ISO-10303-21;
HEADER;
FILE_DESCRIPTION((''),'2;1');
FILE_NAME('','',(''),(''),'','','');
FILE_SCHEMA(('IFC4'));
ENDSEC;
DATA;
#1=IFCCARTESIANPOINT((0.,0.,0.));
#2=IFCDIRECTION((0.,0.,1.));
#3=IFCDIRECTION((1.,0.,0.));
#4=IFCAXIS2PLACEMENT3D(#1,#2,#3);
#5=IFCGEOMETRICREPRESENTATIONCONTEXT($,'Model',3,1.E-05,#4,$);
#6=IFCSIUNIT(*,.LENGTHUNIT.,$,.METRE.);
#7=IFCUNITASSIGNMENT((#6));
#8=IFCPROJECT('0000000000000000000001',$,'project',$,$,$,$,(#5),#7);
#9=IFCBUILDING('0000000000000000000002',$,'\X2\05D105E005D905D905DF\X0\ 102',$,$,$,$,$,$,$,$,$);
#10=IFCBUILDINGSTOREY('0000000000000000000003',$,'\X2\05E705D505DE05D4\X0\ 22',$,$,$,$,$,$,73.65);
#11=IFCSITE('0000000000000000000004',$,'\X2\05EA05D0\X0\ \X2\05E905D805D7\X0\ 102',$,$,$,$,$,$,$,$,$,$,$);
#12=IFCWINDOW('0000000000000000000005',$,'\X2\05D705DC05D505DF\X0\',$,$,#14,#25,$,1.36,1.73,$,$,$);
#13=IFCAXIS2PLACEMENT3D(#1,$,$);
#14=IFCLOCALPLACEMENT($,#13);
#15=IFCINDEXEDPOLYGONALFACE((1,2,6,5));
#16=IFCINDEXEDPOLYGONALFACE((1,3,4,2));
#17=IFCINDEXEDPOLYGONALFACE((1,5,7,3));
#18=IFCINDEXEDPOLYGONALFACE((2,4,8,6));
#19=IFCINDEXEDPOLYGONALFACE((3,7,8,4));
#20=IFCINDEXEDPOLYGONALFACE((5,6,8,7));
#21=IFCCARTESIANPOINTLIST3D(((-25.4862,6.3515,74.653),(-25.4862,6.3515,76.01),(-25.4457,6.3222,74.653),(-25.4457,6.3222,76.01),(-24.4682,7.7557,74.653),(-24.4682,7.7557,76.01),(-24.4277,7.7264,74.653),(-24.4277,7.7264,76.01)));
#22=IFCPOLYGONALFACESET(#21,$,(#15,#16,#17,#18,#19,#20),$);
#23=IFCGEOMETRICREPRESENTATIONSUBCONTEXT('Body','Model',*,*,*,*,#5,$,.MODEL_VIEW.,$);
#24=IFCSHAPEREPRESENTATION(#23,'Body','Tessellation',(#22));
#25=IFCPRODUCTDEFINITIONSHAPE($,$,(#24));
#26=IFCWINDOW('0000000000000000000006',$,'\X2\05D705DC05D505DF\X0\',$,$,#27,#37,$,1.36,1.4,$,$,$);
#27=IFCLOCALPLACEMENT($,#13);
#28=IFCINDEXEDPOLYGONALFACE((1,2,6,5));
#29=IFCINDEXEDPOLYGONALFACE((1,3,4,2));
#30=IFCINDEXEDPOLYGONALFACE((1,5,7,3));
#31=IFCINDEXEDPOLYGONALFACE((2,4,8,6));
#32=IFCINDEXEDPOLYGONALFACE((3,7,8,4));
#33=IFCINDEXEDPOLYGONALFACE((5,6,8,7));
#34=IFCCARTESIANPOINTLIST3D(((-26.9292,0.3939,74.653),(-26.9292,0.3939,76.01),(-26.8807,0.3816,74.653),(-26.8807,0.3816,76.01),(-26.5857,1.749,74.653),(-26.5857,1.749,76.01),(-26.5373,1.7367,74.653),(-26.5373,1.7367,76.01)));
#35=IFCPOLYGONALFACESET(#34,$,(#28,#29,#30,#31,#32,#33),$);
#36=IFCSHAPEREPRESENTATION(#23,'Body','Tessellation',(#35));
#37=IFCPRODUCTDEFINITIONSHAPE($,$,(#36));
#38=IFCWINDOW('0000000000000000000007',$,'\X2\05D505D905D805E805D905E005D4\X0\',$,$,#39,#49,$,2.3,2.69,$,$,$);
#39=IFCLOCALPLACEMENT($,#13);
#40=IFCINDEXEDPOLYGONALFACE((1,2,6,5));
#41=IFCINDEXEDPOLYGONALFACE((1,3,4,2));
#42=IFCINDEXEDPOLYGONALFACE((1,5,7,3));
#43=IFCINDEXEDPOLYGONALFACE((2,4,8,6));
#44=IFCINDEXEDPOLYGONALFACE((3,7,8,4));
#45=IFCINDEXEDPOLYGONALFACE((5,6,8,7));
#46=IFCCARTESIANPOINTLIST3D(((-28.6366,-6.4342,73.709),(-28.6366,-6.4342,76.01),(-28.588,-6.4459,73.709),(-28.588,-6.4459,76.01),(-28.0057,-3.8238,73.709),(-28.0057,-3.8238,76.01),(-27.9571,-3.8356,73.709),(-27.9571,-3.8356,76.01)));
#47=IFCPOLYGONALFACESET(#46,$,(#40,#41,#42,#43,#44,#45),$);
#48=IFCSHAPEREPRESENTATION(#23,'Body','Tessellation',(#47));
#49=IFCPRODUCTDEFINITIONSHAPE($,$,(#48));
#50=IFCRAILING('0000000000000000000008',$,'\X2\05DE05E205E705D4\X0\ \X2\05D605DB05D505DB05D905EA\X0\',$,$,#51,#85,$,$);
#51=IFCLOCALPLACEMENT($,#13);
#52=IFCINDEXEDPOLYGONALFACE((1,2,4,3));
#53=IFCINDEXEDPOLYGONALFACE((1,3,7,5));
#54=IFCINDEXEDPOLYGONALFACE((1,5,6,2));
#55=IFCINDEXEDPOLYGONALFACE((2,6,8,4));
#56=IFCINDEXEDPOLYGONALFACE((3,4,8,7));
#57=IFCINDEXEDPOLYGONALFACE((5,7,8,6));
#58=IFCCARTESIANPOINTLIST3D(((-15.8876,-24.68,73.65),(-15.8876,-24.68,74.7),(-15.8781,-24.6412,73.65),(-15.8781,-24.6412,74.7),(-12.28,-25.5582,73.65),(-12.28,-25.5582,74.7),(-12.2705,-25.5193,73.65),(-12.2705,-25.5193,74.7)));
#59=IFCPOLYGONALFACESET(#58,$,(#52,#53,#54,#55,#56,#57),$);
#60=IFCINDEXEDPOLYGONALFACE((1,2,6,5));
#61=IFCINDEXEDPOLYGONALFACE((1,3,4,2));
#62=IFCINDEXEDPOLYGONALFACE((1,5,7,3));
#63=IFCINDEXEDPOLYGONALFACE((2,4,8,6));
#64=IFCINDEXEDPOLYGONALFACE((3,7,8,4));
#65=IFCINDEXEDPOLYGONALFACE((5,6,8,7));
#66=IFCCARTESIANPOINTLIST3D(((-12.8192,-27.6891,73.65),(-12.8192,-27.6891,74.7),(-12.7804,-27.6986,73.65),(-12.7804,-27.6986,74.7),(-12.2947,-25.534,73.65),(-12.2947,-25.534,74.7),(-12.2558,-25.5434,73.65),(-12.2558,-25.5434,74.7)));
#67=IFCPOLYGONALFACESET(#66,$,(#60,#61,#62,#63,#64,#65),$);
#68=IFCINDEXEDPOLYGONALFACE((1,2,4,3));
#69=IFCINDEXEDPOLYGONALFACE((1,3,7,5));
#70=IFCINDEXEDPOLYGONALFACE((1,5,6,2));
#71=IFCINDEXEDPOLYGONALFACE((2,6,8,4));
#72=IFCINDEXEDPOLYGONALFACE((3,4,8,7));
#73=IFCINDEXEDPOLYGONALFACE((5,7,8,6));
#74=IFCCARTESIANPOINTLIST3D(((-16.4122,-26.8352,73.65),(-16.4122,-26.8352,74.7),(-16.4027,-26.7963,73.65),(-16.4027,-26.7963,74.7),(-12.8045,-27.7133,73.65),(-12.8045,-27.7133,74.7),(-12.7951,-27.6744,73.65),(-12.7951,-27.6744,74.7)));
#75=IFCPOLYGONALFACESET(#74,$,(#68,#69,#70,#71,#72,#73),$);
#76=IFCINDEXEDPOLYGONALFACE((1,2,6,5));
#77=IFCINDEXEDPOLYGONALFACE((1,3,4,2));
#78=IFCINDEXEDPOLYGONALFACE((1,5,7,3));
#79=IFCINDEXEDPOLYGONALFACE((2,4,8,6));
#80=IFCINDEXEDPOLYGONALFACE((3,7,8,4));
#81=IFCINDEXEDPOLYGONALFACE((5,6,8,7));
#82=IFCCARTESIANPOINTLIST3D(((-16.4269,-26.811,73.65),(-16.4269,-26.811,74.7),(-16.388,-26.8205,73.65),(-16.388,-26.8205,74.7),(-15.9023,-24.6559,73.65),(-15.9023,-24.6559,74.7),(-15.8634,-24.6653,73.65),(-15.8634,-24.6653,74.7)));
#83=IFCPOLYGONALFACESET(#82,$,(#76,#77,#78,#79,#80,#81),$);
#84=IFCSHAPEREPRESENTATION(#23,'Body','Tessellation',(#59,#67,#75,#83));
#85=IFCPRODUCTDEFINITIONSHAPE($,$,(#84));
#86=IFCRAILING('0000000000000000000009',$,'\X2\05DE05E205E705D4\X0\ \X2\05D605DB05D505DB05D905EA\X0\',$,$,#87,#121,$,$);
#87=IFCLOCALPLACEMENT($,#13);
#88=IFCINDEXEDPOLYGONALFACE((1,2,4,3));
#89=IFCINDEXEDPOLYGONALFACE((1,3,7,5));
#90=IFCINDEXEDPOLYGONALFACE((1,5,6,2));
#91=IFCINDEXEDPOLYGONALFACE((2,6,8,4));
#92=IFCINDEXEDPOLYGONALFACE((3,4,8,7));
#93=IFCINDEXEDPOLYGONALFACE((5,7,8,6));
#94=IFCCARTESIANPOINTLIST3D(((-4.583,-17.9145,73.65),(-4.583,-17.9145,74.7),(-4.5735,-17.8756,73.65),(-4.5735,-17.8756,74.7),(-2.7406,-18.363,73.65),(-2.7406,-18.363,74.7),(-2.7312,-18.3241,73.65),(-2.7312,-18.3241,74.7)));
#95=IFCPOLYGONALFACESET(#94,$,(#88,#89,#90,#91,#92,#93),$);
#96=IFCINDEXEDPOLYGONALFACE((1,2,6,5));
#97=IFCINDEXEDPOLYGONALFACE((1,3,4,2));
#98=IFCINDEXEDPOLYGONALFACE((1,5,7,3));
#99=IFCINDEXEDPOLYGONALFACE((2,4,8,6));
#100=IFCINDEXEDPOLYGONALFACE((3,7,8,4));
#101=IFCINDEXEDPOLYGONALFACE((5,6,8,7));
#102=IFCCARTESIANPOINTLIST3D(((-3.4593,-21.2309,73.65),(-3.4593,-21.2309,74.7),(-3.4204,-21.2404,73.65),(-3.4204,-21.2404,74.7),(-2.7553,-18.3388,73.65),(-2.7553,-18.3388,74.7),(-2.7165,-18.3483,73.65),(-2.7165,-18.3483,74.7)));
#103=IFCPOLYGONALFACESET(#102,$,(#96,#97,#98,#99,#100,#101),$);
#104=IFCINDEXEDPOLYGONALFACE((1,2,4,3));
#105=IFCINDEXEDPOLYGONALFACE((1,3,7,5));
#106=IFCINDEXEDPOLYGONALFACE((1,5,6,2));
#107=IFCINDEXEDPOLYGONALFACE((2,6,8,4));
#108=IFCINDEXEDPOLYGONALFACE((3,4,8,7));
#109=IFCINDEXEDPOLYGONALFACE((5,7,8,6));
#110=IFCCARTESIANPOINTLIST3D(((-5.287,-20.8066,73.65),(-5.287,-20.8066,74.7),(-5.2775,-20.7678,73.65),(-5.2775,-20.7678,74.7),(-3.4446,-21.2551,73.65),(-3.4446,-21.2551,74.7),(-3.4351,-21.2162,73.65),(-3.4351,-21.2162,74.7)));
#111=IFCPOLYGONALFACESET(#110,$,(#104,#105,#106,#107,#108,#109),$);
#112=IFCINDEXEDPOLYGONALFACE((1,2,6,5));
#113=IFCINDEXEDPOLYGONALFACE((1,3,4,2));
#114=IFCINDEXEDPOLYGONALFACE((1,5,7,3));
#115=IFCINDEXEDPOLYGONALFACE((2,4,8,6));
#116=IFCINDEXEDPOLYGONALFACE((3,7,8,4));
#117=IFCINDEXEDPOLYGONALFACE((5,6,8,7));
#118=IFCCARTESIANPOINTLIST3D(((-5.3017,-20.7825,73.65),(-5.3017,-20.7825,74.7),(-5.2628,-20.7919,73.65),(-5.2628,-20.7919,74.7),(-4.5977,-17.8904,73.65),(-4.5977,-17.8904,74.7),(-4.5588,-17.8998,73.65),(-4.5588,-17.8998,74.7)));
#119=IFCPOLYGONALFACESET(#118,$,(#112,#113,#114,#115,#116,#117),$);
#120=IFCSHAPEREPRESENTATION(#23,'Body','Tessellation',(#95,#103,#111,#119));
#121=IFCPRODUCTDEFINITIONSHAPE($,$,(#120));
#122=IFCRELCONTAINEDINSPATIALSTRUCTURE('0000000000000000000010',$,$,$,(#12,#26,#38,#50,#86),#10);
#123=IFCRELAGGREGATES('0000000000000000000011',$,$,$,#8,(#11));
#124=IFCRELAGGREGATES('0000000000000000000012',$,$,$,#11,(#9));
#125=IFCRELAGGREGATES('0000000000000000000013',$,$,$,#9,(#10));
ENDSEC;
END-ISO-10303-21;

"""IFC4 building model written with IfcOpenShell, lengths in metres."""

from ifc_helpers import new_model, si_unit, frame, origin_with_axes, context, subcontext, project, spatial, polyline, outline, extrude, element, save


model = new_model("IFC4")

# Units and contexts
model_context = context("Model", 3, precision=1e-05, world=origin_with_axes())
body_context = subcontext(model_context, "Body", "Model", "MODEL_VIEW")
ifc_project = project(units=[si_unit("LENGTHUNIT", "METRE")], contexts=[model_context])

# Site, building, storey
site = spatial("IfcSite", under=ifc_project, Name="תא שטח 102")
building = spatial("IfcBuilding", under=site, Name="בניין 102")
storey = spatial("IfcBuildingStorey", under=building, Name="קומה 22", Elevation=73.65)

# Windows
element("IfcWindow", 1, inside=storey, Name="חלון", OverallHeight=1.36, OverallWidth=1.73, context=body_context, shape_type="SweptSolid", body=[
    extrude(outline(polyline([(-24.4682, 7.7557), (-25.4862, 6.3515), (-25.4457, 6.3222), (-24.4277, 7.7264), (-24.4682, 7.7557)])), frame((0.0, 0.0, 74.653)), (0.0, 0.0, 1.0), 1.357),
])
element("IfcWindow", 2, inside=storey, Name="חלון", OverallHeight=1.36, OverallWidth=1.4, context=body_context, shape_type="SweptSolid", body=[
    extrude(outline(polyline([(-26.5857, 1.749), (-26.9292, 0.3939), (-26.8807, 0.3816), (-26.5373, 1.7367), (-26.5857, 1.749)])), frame((0.0, 0.0, 74.653)), (0.0, 0.0, 1.0), 1.357),
])
element("IfcWindow", 3, inside=storey, Name="ויטרינה", OverallHeight=2.3, OverallWidth=2.69, context=body_context, shape_type="SweptSolid", body=[
    extrude(outline(polyline([(-28.0057, -3.8238), (-28.6366, -6.4342), (-28.588, -6.4459), (-27.9571, -3.8356), (-28.0057, -3.8238)])), frame((0.0, 0.0, 73.709)), (0.0, 0.0, 1.0), 2.301),
])

# Railings
element("IfcRailing", 4, inside=storey, Name="מעקה זכוכית", context=body_context, shape_type="SweptSolid", body=[
    extrude(outline(polyline([(-15.8876, -24.68), (-12.28, -25.5582), (-12.2705, -25.5193), (-15.8781, -24.6412), (-15.8876, -24.68)])), frame((0.0, 0.0, 73.65)), (0.0, 0.0, 1.0), 1.05),
    extrude(outline(polyline([(-12.2947, -25.534), (-12.8192, -27.6891), (-12.7804, -27.6986), (-12.2558, -25.5434), (-12.2947, -25.534)])), frame((0.0, 0.0, 73.65)), (0.0, 0.0, 1.0), 1.05),
    extrude(outline(polyline([(-12.7951, -27.6744), (-16.4027, -26.7963), (-16.4122, -26.8352), (-12.8045, -27.7133), (-12.7951, -27.6744)])), frame((0.0, 0.0, 73.65)), (0.0, 0.0, 1.0), 1.05),
    extrude(outline(polyline([(-16.388, -26.8205), (-15.8634, -24.6653), (-15.9023, -24.6559), (-16.4269, -26.811), (-16.388, -26.8205)])), frame((0.0, 0.0, 73.65)), (0.0, 0.0, 1.0), 1.05),
])
element("IfcRailing", 5, inside=storey, Name="מעקה זכוכית", context=body_context, shape_type="SweptSolid", body=[
    extrude(outline(polyline([(-4.583, -17.9145), (-2.7406, -18.363), (-2.7312, -18.3241), (-4.5735, -17.8756), (-4.583, -17.9145)])), frame((0.0, 0.0, 73.65)), (0.0, 0.0, 1.0), 1.05),
    extrude(outline(polyline([(-2.7553, -18.3388), (-3.4593, -21.2309), (-3.4204, -21.2404), (-2.7165, -18.3483), (-2.7553, -18.3388)])), frame((0.0, 0.0, 73.65)), (0.0, 0.0, 1.0), 1.05),
    extrude(outline(polyline([(-3.4351, -21.2162), (-5.2775, -20.7678), (-5.287, -20.8066), (-3.4446, -21.2551), (-3.4351, -21.2162)])), frame((0.0, 0.0, 73.65)), (0.0, 0.0, 1.0), 1.05),
    extrude(outline(polyline([(-5.2628, -20.7919), (-4.5588, -17.8998), (-4.5977, -17.8904), (-5.3017, -20.7825), (-5.2628, -20.7919)])), frame((0.0, 0.0, 73.65)), (0.0, 0.0, 1.0), 1.05),
])

save(model, "model.ifc")
